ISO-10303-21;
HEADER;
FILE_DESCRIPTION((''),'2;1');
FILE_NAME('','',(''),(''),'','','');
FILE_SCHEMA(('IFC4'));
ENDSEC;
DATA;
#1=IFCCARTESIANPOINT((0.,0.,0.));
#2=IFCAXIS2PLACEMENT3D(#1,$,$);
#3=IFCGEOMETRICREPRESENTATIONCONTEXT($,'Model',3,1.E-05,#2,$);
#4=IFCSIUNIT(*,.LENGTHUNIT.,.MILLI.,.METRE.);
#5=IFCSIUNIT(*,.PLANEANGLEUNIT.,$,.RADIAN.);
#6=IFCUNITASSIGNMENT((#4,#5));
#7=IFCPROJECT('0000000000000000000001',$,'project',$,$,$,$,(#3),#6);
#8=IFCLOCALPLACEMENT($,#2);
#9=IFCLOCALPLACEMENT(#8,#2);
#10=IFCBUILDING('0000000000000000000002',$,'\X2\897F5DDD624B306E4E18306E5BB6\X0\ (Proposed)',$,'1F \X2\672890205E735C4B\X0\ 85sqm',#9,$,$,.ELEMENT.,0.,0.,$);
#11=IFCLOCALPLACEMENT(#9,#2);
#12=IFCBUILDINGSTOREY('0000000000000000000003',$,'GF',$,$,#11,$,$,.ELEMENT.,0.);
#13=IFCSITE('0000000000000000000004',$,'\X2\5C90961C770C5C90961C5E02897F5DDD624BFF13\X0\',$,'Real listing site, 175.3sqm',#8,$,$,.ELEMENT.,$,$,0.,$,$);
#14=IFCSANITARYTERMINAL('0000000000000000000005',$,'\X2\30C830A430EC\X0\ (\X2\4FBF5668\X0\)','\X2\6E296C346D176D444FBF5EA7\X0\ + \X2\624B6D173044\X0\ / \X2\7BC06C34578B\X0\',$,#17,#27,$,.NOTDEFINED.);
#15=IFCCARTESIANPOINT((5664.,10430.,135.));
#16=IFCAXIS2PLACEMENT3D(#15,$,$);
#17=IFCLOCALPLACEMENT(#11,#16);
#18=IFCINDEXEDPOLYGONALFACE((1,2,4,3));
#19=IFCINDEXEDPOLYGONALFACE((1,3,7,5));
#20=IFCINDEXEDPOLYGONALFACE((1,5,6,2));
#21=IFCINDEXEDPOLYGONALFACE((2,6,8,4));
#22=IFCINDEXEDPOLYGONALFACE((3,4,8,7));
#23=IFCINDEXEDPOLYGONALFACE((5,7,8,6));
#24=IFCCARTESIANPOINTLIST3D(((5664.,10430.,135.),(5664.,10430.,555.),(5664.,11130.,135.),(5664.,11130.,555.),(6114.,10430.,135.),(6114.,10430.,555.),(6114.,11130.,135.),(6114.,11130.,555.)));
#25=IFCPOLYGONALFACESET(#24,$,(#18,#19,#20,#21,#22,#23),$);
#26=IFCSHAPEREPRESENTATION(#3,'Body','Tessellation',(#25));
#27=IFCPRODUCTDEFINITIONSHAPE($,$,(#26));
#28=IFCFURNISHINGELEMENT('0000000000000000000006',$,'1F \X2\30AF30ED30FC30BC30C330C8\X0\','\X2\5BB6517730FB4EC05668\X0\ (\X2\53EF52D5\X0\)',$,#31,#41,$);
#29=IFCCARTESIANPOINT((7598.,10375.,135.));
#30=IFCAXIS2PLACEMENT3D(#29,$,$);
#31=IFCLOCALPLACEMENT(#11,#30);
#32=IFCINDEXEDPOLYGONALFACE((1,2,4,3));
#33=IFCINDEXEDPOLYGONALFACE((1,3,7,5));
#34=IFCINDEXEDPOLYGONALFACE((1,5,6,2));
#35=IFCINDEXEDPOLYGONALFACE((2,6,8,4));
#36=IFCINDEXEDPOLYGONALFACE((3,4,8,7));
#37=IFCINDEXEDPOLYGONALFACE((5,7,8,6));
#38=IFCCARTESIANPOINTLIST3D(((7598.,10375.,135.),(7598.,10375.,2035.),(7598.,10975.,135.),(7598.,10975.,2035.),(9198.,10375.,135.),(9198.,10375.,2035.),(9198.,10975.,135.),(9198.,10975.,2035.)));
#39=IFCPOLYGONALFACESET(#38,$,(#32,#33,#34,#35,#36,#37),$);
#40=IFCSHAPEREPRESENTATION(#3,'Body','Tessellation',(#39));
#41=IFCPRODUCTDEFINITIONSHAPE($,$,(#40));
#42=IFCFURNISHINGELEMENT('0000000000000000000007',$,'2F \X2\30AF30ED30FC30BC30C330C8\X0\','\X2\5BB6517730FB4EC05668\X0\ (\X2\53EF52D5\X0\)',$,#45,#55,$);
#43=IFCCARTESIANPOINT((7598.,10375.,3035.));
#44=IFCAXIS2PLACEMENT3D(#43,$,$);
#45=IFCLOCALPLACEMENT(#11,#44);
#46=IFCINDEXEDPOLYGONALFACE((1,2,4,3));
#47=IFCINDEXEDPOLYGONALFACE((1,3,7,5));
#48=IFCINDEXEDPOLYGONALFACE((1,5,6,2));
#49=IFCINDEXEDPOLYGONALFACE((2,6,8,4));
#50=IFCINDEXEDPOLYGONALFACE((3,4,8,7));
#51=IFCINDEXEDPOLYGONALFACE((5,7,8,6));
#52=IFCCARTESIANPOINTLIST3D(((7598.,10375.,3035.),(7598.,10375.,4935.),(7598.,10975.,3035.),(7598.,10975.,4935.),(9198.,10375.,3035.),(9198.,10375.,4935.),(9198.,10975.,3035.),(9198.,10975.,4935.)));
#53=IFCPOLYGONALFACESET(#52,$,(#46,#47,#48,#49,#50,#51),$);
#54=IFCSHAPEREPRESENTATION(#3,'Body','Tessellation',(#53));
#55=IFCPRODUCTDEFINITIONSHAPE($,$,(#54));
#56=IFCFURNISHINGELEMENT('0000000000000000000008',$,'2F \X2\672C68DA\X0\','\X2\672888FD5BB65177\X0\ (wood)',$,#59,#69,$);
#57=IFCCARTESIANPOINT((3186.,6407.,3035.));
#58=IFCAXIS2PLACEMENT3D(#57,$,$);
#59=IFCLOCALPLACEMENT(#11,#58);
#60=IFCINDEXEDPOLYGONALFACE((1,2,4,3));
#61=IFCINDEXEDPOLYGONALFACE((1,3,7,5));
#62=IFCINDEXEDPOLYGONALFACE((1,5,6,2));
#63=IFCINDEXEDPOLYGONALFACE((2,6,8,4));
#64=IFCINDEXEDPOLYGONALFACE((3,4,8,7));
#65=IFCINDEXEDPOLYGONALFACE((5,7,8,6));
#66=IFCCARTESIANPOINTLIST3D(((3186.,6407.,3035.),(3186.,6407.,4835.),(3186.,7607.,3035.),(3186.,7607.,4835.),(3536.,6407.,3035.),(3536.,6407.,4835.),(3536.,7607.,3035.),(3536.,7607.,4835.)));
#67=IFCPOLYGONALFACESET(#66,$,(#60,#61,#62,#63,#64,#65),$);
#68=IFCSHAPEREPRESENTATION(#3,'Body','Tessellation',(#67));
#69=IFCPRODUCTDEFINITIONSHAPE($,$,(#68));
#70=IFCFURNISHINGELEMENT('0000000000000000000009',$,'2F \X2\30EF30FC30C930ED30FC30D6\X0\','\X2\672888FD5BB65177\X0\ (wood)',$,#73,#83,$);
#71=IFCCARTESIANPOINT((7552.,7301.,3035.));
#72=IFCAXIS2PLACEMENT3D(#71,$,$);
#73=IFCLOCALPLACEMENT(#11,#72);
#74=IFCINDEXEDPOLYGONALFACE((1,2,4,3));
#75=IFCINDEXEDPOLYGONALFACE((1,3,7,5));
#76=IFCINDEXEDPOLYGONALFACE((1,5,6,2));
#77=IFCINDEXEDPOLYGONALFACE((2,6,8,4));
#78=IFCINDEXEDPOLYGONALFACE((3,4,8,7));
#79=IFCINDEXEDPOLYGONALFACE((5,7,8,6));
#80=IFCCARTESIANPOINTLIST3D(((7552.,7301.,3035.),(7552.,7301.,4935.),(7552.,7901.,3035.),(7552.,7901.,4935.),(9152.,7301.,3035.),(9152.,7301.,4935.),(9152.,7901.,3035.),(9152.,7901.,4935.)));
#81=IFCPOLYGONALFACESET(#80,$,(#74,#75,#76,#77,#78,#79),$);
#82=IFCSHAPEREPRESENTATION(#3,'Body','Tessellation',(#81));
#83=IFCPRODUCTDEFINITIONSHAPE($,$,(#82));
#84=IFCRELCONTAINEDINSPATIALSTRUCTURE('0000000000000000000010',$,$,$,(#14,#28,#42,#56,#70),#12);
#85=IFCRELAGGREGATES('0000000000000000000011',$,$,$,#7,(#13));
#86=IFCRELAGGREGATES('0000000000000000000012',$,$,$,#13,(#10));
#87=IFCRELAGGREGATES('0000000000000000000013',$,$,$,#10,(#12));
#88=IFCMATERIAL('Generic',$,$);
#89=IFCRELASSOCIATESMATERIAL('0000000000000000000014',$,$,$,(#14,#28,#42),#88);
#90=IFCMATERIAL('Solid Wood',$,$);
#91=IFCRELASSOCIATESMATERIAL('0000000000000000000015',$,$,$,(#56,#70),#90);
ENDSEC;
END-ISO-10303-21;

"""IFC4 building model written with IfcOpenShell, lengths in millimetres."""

from ifc_helpers import new_model, si_unit, frame, frame_2d, origin, place, context, project, spatial, rectangle, extrude, material, element, save


model = new_model("IFC4")

# Units and contexts
model_context = context("Model", 3, precision=1e-05, world=origin())
ifc_project = project(units=[si_unit("LENGTHUNIT", "METRE", prefix="MILLI"), si_unit("PLANEANGLEUNIT", "RADIAN")], contexts=[model_context])

# Site, building, storey
site_placement = place(None, origin())
site = spatial("IfcSite", under=ifc_project, at=site_placement, Name="岐阜県岐阜市西川手３", ObjectType="Real listing site, 175.3sqm", CompositionType="ELEMENT", RefElevation=0.0)
building_placement = place(site_placement, origin())
building = spatial("IfcBuilding", under=site, at=building_placement, Name="西川手の丘の家 (Proposed)", ObjectType="1F 木造平屋 85sqm", CompositionType="ELEMENT", ElevationOfRefHeight=0.0, ElevationOfTerrain=0.0)
storey_placement = place(building_placement, origin())
storey = spatial("IfcBuildingStorey", under=building, at=storey_placement, Name="GF", CompositionType="ELEMENT", Elevation=0.0)

# Shared definitions
ifc_material_1 = material(Name="Solid Wood")

# Shared definitions
ifc_material_2 = material(Name="Generic")

# Sanitary terminal
sanitary_terminal_1_placement = place(storey_placement, frame((5664.0, 10430.0, 135.0)))
element("IfcSanitaryTerminal", 1, at=sanitary_terminal_1_placement, inside=storey, material=ifc_material_2, Name="トイレ (便器)", Description="温水洗浄便座 + 手洗い / 節水型", PredefinedType="NOTDEFINED", context=model_context, shape_type="SweptSolid", body=[
    extrude(rectangle(XDim=450.0, YDim=700.0, at=frame_2d((225.0, 350.0))), frame((5664.0, 10430.0, 135.0)), (0.0, 0.0, 1.0), 420.0),
])

# Furnishing elements
furnishing_1_placement = place(storey_placement, frame((7598.0, 10375.0, 135.0)))
element("IfcFurnishingElement", 2, at=furnishing_1_placement, inside=storey, material=ifc_material_2, Name="1F クローゼット", Description="家具・什器 (可動)", context=model_context, shape_type="SweptSolid", body=[
    extrude(rectangle(XDim=1600.0, YDim=600.0, at=frame_2d((800.0, 300.0))), frame((7598.0, 10375.0, 135.0)), (0.0, 0.0, 1.0), 1900.0),
])
furnishing_2_placement = place(storey_placement, frame((7598.0, 10375.0, 3035.0)))
element("IfcFurnishingElement", 3, at=furnishing_2_placement, inside=storey, material=ifc_material_2, Name="2F クローゼット", Description="家具・什器 (可動)", context=model_context, shape_type="SweptSolid", body=[
    extrude(rectangle(XDim=1600.0, YDim=600.0, at=frame_2d((800.0, 300.0))), frame((7598.0, 10375.0, 3035.0)), (0.0, 0.0, 1.0), 1900.0),
])
furnishing_3_placement = place(storey_placement, frame((3186.0, 6407.0, 3035.0)))
element("IfcFurnishingElement", 4, at=furnishing_3_placement, inside=storey, material=ifc_material_1, Name="2F 本棚", Description="木製家具 (wood)", context=model_context, shape_type="SweptSolid", body=[
    extrude(rectangle(XDim=350.0, YDim=1200.0, at=frame_2d((175.0, 600.0))), frame((3186.0, 6407.0, 3035.0)), (0.0, 0.0, 1.0), 1800.0),
])
furnishing_4_placement = place(storey_placement, frame((7552.0, 7301.0, 3035.0)))
element("IfcFurnishingElement", 5, at=furnishing_4_placement, inside=storey, material=ifc_material_1, Name="2F ワードローブ", Description="木製家具 (wood)", context=model_context, shape_type="SweptSolid", body=[
    extrude(rectangle(XDim=1600.0, YDim=600.0, at=frame_2d((800.0, 300.0))), frame((7552.0, 7301.0, 3035.0)), (0.0, 0.0, 1.0), 1900.0),
])

save(model, "model.ifc")
